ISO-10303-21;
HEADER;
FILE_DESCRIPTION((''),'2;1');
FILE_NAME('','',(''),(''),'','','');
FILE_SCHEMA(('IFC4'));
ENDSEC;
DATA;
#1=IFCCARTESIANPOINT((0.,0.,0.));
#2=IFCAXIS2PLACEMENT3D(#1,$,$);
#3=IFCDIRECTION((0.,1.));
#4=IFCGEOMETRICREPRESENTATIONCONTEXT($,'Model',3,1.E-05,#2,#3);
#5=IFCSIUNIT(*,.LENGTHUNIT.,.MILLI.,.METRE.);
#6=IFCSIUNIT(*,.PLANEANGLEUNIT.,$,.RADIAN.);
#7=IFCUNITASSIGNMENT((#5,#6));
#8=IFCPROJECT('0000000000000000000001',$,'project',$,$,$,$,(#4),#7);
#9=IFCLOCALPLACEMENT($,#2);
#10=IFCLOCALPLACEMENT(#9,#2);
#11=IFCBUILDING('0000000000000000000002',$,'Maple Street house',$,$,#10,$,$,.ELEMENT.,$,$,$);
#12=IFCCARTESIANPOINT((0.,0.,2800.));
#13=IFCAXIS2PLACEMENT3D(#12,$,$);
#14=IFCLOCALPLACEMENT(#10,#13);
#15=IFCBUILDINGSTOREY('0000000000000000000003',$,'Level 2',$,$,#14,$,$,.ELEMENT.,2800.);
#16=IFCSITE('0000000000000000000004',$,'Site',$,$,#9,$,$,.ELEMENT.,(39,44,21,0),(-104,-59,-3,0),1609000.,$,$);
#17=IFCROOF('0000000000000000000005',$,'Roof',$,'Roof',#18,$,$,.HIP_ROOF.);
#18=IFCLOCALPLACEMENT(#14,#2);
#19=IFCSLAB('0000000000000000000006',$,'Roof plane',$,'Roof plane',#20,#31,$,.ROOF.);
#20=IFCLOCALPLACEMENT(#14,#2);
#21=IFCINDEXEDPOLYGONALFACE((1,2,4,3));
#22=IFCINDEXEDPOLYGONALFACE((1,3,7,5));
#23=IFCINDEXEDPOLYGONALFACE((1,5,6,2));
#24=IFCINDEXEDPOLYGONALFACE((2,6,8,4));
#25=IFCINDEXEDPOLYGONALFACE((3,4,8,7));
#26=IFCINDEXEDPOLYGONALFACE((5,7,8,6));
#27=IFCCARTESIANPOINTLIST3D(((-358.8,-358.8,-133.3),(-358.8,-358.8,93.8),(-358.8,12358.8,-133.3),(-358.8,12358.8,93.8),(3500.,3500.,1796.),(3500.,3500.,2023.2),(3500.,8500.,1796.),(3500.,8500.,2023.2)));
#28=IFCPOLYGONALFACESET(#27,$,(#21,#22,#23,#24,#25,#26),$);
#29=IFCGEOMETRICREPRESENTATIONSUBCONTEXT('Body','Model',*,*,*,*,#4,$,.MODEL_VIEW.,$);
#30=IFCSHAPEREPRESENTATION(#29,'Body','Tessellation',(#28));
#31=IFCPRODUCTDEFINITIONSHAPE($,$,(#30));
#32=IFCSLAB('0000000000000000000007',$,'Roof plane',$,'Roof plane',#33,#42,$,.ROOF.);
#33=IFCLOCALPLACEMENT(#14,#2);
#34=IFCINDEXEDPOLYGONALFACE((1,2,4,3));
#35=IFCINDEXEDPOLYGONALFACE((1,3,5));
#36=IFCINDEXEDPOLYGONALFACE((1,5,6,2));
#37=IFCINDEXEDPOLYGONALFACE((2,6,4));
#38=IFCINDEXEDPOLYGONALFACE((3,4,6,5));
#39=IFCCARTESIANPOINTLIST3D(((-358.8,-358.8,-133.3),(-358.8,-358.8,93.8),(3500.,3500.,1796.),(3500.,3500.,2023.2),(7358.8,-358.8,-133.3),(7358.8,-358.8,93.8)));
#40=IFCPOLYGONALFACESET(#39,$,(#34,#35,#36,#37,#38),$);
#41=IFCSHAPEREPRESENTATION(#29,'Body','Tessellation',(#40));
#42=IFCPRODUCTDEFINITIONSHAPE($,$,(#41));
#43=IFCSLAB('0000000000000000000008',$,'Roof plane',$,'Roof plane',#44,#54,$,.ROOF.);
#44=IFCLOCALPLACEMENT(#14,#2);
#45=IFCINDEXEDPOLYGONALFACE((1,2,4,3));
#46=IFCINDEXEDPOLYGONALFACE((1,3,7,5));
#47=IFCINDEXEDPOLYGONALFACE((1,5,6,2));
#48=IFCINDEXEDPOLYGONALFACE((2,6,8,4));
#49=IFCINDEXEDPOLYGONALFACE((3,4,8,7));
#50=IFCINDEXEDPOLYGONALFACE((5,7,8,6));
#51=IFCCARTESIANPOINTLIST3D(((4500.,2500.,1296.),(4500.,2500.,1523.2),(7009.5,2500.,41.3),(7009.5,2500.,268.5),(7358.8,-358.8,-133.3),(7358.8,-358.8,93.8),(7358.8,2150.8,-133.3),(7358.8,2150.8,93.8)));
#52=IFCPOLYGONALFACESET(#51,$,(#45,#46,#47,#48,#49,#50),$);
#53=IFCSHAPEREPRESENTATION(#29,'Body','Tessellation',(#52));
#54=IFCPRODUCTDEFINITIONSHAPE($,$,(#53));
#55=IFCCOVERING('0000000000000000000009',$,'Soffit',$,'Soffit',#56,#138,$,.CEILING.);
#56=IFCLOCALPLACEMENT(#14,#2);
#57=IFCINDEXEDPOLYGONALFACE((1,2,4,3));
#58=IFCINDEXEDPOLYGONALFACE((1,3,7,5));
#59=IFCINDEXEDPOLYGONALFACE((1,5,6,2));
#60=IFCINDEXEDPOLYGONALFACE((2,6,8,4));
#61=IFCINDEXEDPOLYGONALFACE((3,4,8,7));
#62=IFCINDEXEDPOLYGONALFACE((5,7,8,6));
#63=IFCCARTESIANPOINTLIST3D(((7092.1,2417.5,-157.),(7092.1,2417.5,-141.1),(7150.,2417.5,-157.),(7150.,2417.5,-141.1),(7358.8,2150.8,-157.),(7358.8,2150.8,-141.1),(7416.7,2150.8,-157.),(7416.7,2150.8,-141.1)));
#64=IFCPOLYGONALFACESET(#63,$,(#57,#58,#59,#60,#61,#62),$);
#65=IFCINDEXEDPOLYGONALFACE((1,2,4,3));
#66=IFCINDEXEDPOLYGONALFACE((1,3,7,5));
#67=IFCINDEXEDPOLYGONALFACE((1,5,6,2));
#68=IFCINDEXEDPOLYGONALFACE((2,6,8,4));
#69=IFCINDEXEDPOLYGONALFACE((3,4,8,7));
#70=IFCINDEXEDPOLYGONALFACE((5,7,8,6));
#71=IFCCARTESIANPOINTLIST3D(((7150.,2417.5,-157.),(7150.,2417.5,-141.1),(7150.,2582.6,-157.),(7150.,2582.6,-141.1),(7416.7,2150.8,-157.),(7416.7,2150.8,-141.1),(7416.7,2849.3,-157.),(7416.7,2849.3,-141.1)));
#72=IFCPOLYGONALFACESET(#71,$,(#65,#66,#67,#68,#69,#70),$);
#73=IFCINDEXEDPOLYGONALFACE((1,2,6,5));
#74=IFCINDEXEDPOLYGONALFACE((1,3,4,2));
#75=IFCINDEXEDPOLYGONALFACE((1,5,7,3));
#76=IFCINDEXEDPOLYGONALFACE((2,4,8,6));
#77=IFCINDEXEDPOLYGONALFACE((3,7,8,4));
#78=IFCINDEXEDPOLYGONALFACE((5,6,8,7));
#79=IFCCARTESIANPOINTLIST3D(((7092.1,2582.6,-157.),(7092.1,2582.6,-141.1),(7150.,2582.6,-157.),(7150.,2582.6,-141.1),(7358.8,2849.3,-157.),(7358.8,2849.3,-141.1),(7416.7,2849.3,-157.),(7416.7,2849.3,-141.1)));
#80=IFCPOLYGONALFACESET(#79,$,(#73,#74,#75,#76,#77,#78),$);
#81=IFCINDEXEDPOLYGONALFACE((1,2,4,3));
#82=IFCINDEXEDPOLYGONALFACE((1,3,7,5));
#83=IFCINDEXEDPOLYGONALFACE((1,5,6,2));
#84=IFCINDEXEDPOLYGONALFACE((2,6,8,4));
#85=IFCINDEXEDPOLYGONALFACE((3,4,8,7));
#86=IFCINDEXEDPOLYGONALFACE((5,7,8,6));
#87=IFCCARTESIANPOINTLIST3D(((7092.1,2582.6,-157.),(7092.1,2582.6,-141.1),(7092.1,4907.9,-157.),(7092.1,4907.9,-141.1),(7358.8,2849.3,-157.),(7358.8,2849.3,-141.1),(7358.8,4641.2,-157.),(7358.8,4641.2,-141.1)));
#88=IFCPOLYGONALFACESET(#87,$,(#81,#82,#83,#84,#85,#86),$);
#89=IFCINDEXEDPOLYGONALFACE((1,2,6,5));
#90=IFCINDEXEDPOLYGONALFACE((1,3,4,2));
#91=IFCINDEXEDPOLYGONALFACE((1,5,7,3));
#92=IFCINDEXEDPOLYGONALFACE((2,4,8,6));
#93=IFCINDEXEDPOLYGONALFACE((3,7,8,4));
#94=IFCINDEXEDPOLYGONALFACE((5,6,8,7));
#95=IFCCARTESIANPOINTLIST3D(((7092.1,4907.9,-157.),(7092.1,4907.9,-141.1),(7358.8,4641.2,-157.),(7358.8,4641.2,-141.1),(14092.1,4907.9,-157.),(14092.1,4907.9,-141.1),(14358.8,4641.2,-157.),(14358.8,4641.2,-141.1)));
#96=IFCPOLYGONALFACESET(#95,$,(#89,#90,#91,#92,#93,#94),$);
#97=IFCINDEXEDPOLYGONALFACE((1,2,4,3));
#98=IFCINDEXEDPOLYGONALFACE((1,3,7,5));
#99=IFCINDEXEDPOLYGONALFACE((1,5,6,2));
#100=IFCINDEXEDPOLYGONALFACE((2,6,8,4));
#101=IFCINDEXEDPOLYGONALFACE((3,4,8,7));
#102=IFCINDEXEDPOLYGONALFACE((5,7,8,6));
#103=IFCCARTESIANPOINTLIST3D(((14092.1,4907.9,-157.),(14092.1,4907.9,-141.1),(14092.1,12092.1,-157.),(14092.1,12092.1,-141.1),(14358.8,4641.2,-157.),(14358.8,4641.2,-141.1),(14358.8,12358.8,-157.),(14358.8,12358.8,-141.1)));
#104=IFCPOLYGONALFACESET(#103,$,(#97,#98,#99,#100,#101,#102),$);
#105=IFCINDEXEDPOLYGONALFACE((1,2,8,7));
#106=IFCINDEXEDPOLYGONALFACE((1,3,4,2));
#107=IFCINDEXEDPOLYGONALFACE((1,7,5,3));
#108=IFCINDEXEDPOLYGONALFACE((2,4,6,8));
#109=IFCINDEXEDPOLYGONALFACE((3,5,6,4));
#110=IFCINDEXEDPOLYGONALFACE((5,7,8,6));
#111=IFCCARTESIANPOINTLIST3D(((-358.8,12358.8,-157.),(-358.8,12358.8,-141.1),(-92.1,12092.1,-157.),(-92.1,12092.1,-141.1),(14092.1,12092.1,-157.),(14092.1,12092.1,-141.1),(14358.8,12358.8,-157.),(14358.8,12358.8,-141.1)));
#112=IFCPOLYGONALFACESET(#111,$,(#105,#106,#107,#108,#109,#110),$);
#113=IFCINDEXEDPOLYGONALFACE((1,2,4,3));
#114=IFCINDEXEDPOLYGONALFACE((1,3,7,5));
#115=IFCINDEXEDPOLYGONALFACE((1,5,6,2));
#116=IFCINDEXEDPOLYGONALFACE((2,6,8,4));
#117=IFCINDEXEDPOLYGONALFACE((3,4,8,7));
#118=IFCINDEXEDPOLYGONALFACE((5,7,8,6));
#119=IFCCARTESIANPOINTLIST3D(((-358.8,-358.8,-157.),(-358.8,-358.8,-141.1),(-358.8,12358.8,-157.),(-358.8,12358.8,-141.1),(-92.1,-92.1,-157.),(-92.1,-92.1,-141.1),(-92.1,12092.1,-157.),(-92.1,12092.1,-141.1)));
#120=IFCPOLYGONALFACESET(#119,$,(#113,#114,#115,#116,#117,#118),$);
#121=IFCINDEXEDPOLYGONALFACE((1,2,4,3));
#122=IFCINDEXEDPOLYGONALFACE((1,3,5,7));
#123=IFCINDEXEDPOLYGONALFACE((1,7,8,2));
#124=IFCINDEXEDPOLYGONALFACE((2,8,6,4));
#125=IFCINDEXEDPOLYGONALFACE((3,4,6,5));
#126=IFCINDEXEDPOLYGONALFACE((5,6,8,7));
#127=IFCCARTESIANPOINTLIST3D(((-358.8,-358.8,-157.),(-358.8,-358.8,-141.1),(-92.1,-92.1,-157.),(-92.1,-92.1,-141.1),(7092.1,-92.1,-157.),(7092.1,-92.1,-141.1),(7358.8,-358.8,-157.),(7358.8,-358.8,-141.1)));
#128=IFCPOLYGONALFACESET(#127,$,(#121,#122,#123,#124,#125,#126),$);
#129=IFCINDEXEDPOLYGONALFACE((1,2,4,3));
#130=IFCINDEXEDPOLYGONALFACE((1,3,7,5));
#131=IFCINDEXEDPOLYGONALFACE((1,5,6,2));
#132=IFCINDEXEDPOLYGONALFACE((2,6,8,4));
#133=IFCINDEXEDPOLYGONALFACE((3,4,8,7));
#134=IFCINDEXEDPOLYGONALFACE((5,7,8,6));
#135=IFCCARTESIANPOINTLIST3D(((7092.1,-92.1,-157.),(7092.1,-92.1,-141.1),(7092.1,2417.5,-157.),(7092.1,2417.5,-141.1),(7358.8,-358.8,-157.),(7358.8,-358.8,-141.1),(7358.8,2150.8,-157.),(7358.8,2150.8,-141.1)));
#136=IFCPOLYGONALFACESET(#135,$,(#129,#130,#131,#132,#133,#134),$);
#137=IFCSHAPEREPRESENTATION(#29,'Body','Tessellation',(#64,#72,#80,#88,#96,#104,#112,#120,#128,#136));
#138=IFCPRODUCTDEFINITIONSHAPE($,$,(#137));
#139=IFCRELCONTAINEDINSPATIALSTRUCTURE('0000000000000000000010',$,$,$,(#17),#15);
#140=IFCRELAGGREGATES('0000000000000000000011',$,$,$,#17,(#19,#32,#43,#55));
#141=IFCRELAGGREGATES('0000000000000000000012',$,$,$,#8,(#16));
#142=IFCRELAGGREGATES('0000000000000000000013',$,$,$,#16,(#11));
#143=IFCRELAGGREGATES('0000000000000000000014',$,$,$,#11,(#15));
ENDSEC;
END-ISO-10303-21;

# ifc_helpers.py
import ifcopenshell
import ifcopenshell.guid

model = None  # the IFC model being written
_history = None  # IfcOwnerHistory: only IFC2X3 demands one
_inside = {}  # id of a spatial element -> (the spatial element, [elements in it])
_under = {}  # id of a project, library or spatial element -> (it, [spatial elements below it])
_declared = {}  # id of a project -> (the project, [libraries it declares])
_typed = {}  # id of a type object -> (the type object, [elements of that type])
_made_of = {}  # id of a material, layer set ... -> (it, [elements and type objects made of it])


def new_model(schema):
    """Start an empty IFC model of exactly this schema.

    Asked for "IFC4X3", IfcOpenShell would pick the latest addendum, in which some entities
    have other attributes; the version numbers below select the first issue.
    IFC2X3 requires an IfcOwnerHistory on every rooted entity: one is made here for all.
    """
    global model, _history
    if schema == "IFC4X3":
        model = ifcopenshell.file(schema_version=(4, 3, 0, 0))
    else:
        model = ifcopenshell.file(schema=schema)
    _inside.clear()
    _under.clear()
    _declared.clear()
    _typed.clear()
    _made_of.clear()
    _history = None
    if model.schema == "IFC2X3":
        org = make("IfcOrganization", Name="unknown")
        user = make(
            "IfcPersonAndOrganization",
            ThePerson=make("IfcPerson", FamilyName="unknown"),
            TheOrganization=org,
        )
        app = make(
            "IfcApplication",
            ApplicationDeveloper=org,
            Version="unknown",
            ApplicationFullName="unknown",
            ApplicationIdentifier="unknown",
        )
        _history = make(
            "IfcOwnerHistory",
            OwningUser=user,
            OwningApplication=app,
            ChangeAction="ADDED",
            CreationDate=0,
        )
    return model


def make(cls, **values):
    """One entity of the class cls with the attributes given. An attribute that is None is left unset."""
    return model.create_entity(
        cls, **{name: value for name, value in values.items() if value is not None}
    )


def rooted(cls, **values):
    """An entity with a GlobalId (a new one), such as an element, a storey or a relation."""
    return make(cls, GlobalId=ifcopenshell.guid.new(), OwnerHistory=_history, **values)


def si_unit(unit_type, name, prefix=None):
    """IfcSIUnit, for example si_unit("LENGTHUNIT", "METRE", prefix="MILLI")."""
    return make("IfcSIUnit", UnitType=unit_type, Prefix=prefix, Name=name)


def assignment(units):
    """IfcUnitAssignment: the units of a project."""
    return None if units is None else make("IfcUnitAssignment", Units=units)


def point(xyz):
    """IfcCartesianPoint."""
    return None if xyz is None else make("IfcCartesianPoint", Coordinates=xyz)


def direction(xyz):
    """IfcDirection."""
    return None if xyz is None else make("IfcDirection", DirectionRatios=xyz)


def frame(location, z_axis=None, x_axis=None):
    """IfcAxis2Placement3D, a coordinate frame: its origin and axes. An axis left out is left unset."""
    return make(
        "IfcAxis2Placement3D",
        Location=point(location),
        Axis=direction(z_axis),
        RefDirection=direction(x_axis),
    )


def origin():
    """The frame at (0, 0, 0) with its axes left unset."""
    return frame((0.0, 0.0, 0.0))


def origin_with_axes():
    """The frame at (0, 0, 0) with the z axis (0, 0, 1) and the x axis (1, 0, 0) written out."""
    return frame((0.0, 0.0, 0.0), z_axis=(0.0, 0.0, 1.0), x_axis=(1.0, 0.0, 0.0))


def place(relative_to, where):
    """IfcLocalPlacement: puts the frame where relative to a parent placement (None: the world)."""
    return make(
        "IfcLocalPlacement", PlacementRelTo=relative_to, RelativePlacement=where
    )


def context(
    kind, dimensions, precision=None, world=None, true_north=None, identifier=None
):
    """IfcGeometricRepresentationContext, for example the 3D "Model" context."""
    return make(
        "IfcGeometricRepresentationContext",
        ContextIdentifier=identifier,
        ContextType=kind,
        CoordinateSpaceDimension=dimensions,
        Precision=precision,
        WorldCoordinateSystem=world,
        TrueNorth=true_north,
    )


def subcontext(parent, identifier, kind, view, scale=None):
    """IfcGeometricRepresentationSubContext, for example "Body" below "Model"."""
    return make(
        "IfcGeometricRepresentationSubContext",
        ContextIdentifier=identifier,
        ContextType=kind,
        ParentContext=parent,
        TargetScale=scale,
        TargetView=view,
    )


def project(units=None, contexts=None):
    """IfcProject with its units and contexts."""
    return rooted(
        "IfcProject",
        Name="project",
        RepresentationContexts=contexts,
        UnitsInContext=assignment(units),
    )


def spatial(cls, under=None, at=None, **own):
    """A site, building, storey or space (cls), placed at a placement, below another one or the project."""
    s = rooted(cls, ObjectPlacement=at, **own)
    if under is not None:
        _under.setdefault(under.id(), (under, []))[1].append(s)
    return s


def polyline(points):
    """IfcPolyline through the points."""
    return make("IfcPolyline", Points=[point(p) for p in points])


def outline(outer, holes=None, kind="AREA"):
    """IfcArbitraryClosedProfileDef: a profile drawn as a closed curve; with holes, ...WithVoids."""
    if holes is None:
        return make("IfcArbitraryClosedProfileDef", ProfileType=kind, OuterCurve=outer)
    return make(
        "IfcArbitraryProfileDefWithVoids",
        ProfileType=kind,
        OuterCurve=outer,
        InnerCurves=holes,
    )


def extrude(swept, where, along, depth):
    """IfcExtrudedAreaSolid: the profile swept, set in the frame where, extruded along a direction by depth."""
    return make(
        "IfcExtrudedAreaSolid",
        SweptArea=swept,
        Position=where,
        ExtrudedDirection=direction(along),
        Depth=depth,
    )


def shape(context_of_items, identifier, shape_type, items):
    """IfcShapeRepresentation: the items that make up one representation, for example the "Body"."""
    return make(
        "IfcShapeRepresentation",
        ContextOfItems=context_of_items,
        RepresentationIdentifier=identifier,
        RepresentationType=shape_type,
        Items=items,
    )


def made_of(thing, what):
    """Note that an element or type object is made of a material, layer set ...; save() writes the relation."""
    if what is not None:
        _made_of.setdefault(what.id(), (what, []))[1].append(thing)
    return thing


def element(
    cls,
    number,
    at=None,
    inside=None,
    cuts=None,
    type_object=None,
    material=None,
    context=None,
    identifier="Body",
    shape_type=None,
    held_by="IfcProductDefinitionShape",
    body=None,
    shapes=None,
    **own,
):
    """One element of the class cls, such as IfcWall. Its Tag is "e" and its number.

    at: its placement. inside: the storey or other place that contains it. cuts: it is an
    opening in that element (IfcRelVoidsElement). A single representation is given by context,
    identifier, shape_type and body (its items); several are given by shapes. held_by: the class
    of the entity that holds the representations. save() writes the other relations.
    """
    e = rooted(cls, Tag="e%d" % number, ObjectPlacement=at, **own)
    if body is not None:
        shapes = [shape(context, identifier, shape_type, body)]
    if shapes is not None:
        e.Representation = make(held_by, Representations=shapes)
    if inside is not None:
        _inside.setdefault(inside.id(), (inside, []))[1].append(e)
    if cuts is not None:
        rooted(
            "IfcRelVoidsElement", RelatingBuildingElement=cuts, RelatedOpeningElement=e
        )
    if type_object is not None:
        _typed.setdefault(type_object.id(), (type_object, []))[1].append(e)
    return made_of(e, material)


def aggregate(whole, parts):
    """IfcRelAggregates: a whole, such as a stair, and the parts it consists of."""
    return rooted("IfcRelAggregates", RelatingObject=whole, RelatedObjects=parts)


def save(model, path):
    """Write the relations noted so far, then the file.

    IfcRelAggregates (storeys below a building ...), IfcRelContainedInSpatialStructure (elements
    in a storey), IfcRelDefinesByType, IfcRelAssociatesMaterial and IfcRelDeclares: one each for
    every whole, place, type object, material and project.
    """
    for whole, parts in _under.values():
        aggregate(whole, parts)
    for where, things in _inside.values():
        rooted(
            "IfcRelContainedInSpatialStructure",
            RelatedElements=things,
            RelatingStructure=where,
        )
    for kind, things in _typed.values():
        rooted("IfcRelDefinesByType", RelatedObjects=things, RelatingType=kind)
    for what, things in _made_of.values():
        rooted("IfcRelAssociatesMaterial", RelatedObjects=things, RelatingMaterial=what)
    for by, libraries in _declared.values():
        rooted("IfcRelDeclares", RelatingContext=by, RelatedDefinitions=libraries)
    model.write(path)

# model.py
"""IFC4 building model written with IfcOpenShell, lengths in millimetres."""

from ifc_helpers import new_model, si_unit, direction, frame, origin, origin_with_axes, place, context, subcontext, project, spatial, polyline, outline, extrude, element, aggregate, save


model = new_model("IFC4")

# Units and contexts
model_context = context("Model", 3, precision=1e-05, world=origin(), true_north=direction((0.0, 1.0)))
body_context = subcontext(model_context, "Body", "Model", "MODEL_VIEW")
ifc_project = project(units=[si_unit("LENGTHUNIT", "METRE", prefix="MILLI"), si_unit("PLANEANGLEUNIT", "RADIAN")], contexts=[model_context])

# Site, building, storey
site_placement = place(None, origin())
site = spatial("IfcSite", under=ifc_project, at=site_placement, Name="Site", CompositionType="ELEMENT", RefLatitude=(39, 44, 21, 0), RefLongitude=(-104, -59, -3, 0), RefElevation=1609000.0)
building_placement = place(site_placement, origin())
building = spatial("IfcBuilding", under=site, at=building_placement, Name="Maple Street house", CompositionType="ELEMENT")
storey_placement = place(building_placement, frame((0.0, 0.0, 2800.0)))
storey = spatial("IfcBuildingStorey", under=building, at=storey_placement, Name="Level 2", CompositionType="ELEMENT", Elevation=2800.0)

# Roof
roof_1_placement = place(storey_placement, origin_with_axes())
roof_1 = element("IfcRoof", 1, at=roof_1_placement, inside=storey, Name="Roof", ObjectType="Roof", PredefinedType="HIP_ROOF")

# Slabs
slab_1_placement = place(storey_placement, origin_with_axes())
slab_1 = element("IfcSlab", 2, at=slab_1_placement, Name="Roof plane", ObjectType="Roof plane", PredefinedType="ROOF", context=body_context, shape_type="SweptSolid", body=[
    extrude(outline(polyline([(-12358.8, 0.0), (358.8, 0.0), (-3500.0, 4314.2), (-8500.0, 4314.2), (-12358.8, 0.0)])), frame((-358.8, 0.0, -133.3), z_axis=(-0.447214, 0.0, 0.894427), x_axis=(0.0, -1.0, 0.0)), (0.0, 0.447214, 0.894427), 227.2),
])
slab_2_placement = place(storey_placement, origin_with_axes())
slab_2 = element("IfcSlab", 3, at=slab_2_placement, Name="Roof plane", ObjectType="Roof plane", PredefinedType="ROOF", context=body_context, shape_type="SweptSolid", body=[
    extrude(outline(polyline([(-358.8, 0.0), (7358.8, 0.0), (3500.0, 4314.2), (-358.8, 0.0)])), frame((0.0, -358.8, -133.3), z_axis=(0.0, -0.447214, 0.894427), x_axis=(1.0, 0.0, 0.0)), (0.0, 0.447214, 0.894427), 227.2),
])
slab_3_placement = place(storey_placement, origin_with_axes())
slab_3 = element("IfcSlab", 4, at=slab_3_placement, Name="Roof plane", ObjectType="Roof plane", PredefinedType="ROOF", context=body_context, shape_type="SweptSolid", body=[
    extrude(outline(polyline([(-358.8, 0.0), (2150.8, 0.0), (2500.0, 390.5), (2500.0, 3196.2), (-358.8, 0.0)])), frame((7358.8, 0.0, -133.3), z_axis=(0.447214, 0.0, 0.894427), x_axis=(0.0, 1.0, 0.0)), (0.0, 0.447214, 0.894427), 227.2),
])

# Covering
covering_placement = place(storey_placement, origin_with_axes())
covering = element("IfcCovering", 5, at=covering_placement, Name="Soffit", ObjectType="Soffit", PredefinedType="CEILING", context=body_context, shape_type="SweptSolid", body=[
    extrude(outline(polyline([(7092.1, 2417.5), (7150.0, 2417.5), (7416.7, 2150.8), (7358.8, 2150.8), (7092.1, 2417.5)])), frame((0.0, 0.0, -157.0), z_axis=(0.0, 0.0, 1.0), x_axis=(1.0, 0.0, 0.0)), (0.0, 0.0, 1.0), 15.9),
    extrude(outline(polyline([(7150.0, 2417.5), (7150.0, 2582.6), (7416.7, 2849.3), (7416.7, 2150.8), (7150.0, 2417.5)])), frame((0.0, 0.0, -157.0), z_axis=(0.0, 0.0, 1.0), x_axis=(1.0, 0.0, 0.0)), (0.0, 0.0, 1.0), 15.9),
    extrude(outline(polyline([(7150.0, 2582.6), (7092.1, 2582.6), (7358.8, 2849.3), (7416.7, 2849.3), (7150.0, 2582.6)])), frame((0.0, 0.0, -157.0), z_axis=(0.0, 0.0, 1.0), x_axis=(1.0, 0.0, 0.0)), (0.0, 0.0, 1.0), 15.9),
    extrude(outline(polyline([(7092.1, 2582.6), (7092.1, 4907.9), (7358.8, 4641.2), (7358.8, 2849.3), (7092.1, 2582.6)])), frame((0.0, 0.0, -157.0), z_axis=(0.0, 0.0, 1.0), x_axis=(1.0, 0.0, 0.0)), (0.0, 0.0, 1.0), 15.9),
    extrude(outline(polyline([(7092.1, 4907.9), (14092.1, 4907.9), (14358.8, 4641.2), (7358.8, 4641.2), (7092.1, 4907.9)])), frame((0.0, 0.0, -157.0), z_axis=(0.0, 0.0, 1.0), x_axis=(1.0, 0.0, 0.0)), (0.0, 0.0, 1.0), 15.9),
    extrude(outline(polyline([(14092.1, 4907.9), (14092.1, 12092.1), (14358.8, 12358.8), (14358.8, 4641.2), (14092.1, 4907.9)])), frame((0.0, 0.0, -157.0), z_axis=(0.0, 0.0, 1.0), x_axis=(1.0, 0.0, 0.0)), (0.0, 0.0, 1.0), 15.9),
    extrude(outline(polyline([(14092.1, 12092.1), (-92.1, 12092.1), (-358.8, 12358.8), (14358.8, 12358.8), (14092.1, 12092.1)])), frame((0.0, 0.0, -157.0), z_axis=(0.0, 0.0, 1.0), x_axis=(1.0, 0.0, 0.0)), (0.0, 0.0, 1.0), 15.9),
    extrude(outline(polyline([(-92.1, 12092.1), (-92.1, -92.1), (-358.8, -358.8), (-358.8, 12358.8), (-92.1, 12092.1)])), frame((0.0, 0.0, -157.0), z_axis=(0.0, 0.0, 1.0), x_axis=(1.0, 0.0, 0.0)), (0.0, 0.0, 1.0), 15.9),
    extrude(outline(polyline([(-92.1, -92.1), (7092.1, -92.1), (7358.8, -358.8), (-358.8, -358.8), (-92.1, -92.1)])), frame((0.0, 0.0, -157.0), z_axis=(0.0, 0.0, 1.0), x_axis=(1.0, 0.0, 0.0)), (0.0, 0.0, 1.0), 15.9),
    extrude(outline(polyline([(7092.1, -92.1), (7092.1, 2417.5), (7358.8, 2150.8), (7358.8, -358.8), (7092.1, -92.1)])), frame((0.0, 0.0, -157.0), z_axis=(0.0, 0.0, 1.0), x_axis=(1.0, 0.0, 0.0)), (0.0, 0.0, 1.0), 15.9),
])
aggregate(roof_1, [slab_1, slab_2, slab_3, covering])

save(model, "model.ifc")
